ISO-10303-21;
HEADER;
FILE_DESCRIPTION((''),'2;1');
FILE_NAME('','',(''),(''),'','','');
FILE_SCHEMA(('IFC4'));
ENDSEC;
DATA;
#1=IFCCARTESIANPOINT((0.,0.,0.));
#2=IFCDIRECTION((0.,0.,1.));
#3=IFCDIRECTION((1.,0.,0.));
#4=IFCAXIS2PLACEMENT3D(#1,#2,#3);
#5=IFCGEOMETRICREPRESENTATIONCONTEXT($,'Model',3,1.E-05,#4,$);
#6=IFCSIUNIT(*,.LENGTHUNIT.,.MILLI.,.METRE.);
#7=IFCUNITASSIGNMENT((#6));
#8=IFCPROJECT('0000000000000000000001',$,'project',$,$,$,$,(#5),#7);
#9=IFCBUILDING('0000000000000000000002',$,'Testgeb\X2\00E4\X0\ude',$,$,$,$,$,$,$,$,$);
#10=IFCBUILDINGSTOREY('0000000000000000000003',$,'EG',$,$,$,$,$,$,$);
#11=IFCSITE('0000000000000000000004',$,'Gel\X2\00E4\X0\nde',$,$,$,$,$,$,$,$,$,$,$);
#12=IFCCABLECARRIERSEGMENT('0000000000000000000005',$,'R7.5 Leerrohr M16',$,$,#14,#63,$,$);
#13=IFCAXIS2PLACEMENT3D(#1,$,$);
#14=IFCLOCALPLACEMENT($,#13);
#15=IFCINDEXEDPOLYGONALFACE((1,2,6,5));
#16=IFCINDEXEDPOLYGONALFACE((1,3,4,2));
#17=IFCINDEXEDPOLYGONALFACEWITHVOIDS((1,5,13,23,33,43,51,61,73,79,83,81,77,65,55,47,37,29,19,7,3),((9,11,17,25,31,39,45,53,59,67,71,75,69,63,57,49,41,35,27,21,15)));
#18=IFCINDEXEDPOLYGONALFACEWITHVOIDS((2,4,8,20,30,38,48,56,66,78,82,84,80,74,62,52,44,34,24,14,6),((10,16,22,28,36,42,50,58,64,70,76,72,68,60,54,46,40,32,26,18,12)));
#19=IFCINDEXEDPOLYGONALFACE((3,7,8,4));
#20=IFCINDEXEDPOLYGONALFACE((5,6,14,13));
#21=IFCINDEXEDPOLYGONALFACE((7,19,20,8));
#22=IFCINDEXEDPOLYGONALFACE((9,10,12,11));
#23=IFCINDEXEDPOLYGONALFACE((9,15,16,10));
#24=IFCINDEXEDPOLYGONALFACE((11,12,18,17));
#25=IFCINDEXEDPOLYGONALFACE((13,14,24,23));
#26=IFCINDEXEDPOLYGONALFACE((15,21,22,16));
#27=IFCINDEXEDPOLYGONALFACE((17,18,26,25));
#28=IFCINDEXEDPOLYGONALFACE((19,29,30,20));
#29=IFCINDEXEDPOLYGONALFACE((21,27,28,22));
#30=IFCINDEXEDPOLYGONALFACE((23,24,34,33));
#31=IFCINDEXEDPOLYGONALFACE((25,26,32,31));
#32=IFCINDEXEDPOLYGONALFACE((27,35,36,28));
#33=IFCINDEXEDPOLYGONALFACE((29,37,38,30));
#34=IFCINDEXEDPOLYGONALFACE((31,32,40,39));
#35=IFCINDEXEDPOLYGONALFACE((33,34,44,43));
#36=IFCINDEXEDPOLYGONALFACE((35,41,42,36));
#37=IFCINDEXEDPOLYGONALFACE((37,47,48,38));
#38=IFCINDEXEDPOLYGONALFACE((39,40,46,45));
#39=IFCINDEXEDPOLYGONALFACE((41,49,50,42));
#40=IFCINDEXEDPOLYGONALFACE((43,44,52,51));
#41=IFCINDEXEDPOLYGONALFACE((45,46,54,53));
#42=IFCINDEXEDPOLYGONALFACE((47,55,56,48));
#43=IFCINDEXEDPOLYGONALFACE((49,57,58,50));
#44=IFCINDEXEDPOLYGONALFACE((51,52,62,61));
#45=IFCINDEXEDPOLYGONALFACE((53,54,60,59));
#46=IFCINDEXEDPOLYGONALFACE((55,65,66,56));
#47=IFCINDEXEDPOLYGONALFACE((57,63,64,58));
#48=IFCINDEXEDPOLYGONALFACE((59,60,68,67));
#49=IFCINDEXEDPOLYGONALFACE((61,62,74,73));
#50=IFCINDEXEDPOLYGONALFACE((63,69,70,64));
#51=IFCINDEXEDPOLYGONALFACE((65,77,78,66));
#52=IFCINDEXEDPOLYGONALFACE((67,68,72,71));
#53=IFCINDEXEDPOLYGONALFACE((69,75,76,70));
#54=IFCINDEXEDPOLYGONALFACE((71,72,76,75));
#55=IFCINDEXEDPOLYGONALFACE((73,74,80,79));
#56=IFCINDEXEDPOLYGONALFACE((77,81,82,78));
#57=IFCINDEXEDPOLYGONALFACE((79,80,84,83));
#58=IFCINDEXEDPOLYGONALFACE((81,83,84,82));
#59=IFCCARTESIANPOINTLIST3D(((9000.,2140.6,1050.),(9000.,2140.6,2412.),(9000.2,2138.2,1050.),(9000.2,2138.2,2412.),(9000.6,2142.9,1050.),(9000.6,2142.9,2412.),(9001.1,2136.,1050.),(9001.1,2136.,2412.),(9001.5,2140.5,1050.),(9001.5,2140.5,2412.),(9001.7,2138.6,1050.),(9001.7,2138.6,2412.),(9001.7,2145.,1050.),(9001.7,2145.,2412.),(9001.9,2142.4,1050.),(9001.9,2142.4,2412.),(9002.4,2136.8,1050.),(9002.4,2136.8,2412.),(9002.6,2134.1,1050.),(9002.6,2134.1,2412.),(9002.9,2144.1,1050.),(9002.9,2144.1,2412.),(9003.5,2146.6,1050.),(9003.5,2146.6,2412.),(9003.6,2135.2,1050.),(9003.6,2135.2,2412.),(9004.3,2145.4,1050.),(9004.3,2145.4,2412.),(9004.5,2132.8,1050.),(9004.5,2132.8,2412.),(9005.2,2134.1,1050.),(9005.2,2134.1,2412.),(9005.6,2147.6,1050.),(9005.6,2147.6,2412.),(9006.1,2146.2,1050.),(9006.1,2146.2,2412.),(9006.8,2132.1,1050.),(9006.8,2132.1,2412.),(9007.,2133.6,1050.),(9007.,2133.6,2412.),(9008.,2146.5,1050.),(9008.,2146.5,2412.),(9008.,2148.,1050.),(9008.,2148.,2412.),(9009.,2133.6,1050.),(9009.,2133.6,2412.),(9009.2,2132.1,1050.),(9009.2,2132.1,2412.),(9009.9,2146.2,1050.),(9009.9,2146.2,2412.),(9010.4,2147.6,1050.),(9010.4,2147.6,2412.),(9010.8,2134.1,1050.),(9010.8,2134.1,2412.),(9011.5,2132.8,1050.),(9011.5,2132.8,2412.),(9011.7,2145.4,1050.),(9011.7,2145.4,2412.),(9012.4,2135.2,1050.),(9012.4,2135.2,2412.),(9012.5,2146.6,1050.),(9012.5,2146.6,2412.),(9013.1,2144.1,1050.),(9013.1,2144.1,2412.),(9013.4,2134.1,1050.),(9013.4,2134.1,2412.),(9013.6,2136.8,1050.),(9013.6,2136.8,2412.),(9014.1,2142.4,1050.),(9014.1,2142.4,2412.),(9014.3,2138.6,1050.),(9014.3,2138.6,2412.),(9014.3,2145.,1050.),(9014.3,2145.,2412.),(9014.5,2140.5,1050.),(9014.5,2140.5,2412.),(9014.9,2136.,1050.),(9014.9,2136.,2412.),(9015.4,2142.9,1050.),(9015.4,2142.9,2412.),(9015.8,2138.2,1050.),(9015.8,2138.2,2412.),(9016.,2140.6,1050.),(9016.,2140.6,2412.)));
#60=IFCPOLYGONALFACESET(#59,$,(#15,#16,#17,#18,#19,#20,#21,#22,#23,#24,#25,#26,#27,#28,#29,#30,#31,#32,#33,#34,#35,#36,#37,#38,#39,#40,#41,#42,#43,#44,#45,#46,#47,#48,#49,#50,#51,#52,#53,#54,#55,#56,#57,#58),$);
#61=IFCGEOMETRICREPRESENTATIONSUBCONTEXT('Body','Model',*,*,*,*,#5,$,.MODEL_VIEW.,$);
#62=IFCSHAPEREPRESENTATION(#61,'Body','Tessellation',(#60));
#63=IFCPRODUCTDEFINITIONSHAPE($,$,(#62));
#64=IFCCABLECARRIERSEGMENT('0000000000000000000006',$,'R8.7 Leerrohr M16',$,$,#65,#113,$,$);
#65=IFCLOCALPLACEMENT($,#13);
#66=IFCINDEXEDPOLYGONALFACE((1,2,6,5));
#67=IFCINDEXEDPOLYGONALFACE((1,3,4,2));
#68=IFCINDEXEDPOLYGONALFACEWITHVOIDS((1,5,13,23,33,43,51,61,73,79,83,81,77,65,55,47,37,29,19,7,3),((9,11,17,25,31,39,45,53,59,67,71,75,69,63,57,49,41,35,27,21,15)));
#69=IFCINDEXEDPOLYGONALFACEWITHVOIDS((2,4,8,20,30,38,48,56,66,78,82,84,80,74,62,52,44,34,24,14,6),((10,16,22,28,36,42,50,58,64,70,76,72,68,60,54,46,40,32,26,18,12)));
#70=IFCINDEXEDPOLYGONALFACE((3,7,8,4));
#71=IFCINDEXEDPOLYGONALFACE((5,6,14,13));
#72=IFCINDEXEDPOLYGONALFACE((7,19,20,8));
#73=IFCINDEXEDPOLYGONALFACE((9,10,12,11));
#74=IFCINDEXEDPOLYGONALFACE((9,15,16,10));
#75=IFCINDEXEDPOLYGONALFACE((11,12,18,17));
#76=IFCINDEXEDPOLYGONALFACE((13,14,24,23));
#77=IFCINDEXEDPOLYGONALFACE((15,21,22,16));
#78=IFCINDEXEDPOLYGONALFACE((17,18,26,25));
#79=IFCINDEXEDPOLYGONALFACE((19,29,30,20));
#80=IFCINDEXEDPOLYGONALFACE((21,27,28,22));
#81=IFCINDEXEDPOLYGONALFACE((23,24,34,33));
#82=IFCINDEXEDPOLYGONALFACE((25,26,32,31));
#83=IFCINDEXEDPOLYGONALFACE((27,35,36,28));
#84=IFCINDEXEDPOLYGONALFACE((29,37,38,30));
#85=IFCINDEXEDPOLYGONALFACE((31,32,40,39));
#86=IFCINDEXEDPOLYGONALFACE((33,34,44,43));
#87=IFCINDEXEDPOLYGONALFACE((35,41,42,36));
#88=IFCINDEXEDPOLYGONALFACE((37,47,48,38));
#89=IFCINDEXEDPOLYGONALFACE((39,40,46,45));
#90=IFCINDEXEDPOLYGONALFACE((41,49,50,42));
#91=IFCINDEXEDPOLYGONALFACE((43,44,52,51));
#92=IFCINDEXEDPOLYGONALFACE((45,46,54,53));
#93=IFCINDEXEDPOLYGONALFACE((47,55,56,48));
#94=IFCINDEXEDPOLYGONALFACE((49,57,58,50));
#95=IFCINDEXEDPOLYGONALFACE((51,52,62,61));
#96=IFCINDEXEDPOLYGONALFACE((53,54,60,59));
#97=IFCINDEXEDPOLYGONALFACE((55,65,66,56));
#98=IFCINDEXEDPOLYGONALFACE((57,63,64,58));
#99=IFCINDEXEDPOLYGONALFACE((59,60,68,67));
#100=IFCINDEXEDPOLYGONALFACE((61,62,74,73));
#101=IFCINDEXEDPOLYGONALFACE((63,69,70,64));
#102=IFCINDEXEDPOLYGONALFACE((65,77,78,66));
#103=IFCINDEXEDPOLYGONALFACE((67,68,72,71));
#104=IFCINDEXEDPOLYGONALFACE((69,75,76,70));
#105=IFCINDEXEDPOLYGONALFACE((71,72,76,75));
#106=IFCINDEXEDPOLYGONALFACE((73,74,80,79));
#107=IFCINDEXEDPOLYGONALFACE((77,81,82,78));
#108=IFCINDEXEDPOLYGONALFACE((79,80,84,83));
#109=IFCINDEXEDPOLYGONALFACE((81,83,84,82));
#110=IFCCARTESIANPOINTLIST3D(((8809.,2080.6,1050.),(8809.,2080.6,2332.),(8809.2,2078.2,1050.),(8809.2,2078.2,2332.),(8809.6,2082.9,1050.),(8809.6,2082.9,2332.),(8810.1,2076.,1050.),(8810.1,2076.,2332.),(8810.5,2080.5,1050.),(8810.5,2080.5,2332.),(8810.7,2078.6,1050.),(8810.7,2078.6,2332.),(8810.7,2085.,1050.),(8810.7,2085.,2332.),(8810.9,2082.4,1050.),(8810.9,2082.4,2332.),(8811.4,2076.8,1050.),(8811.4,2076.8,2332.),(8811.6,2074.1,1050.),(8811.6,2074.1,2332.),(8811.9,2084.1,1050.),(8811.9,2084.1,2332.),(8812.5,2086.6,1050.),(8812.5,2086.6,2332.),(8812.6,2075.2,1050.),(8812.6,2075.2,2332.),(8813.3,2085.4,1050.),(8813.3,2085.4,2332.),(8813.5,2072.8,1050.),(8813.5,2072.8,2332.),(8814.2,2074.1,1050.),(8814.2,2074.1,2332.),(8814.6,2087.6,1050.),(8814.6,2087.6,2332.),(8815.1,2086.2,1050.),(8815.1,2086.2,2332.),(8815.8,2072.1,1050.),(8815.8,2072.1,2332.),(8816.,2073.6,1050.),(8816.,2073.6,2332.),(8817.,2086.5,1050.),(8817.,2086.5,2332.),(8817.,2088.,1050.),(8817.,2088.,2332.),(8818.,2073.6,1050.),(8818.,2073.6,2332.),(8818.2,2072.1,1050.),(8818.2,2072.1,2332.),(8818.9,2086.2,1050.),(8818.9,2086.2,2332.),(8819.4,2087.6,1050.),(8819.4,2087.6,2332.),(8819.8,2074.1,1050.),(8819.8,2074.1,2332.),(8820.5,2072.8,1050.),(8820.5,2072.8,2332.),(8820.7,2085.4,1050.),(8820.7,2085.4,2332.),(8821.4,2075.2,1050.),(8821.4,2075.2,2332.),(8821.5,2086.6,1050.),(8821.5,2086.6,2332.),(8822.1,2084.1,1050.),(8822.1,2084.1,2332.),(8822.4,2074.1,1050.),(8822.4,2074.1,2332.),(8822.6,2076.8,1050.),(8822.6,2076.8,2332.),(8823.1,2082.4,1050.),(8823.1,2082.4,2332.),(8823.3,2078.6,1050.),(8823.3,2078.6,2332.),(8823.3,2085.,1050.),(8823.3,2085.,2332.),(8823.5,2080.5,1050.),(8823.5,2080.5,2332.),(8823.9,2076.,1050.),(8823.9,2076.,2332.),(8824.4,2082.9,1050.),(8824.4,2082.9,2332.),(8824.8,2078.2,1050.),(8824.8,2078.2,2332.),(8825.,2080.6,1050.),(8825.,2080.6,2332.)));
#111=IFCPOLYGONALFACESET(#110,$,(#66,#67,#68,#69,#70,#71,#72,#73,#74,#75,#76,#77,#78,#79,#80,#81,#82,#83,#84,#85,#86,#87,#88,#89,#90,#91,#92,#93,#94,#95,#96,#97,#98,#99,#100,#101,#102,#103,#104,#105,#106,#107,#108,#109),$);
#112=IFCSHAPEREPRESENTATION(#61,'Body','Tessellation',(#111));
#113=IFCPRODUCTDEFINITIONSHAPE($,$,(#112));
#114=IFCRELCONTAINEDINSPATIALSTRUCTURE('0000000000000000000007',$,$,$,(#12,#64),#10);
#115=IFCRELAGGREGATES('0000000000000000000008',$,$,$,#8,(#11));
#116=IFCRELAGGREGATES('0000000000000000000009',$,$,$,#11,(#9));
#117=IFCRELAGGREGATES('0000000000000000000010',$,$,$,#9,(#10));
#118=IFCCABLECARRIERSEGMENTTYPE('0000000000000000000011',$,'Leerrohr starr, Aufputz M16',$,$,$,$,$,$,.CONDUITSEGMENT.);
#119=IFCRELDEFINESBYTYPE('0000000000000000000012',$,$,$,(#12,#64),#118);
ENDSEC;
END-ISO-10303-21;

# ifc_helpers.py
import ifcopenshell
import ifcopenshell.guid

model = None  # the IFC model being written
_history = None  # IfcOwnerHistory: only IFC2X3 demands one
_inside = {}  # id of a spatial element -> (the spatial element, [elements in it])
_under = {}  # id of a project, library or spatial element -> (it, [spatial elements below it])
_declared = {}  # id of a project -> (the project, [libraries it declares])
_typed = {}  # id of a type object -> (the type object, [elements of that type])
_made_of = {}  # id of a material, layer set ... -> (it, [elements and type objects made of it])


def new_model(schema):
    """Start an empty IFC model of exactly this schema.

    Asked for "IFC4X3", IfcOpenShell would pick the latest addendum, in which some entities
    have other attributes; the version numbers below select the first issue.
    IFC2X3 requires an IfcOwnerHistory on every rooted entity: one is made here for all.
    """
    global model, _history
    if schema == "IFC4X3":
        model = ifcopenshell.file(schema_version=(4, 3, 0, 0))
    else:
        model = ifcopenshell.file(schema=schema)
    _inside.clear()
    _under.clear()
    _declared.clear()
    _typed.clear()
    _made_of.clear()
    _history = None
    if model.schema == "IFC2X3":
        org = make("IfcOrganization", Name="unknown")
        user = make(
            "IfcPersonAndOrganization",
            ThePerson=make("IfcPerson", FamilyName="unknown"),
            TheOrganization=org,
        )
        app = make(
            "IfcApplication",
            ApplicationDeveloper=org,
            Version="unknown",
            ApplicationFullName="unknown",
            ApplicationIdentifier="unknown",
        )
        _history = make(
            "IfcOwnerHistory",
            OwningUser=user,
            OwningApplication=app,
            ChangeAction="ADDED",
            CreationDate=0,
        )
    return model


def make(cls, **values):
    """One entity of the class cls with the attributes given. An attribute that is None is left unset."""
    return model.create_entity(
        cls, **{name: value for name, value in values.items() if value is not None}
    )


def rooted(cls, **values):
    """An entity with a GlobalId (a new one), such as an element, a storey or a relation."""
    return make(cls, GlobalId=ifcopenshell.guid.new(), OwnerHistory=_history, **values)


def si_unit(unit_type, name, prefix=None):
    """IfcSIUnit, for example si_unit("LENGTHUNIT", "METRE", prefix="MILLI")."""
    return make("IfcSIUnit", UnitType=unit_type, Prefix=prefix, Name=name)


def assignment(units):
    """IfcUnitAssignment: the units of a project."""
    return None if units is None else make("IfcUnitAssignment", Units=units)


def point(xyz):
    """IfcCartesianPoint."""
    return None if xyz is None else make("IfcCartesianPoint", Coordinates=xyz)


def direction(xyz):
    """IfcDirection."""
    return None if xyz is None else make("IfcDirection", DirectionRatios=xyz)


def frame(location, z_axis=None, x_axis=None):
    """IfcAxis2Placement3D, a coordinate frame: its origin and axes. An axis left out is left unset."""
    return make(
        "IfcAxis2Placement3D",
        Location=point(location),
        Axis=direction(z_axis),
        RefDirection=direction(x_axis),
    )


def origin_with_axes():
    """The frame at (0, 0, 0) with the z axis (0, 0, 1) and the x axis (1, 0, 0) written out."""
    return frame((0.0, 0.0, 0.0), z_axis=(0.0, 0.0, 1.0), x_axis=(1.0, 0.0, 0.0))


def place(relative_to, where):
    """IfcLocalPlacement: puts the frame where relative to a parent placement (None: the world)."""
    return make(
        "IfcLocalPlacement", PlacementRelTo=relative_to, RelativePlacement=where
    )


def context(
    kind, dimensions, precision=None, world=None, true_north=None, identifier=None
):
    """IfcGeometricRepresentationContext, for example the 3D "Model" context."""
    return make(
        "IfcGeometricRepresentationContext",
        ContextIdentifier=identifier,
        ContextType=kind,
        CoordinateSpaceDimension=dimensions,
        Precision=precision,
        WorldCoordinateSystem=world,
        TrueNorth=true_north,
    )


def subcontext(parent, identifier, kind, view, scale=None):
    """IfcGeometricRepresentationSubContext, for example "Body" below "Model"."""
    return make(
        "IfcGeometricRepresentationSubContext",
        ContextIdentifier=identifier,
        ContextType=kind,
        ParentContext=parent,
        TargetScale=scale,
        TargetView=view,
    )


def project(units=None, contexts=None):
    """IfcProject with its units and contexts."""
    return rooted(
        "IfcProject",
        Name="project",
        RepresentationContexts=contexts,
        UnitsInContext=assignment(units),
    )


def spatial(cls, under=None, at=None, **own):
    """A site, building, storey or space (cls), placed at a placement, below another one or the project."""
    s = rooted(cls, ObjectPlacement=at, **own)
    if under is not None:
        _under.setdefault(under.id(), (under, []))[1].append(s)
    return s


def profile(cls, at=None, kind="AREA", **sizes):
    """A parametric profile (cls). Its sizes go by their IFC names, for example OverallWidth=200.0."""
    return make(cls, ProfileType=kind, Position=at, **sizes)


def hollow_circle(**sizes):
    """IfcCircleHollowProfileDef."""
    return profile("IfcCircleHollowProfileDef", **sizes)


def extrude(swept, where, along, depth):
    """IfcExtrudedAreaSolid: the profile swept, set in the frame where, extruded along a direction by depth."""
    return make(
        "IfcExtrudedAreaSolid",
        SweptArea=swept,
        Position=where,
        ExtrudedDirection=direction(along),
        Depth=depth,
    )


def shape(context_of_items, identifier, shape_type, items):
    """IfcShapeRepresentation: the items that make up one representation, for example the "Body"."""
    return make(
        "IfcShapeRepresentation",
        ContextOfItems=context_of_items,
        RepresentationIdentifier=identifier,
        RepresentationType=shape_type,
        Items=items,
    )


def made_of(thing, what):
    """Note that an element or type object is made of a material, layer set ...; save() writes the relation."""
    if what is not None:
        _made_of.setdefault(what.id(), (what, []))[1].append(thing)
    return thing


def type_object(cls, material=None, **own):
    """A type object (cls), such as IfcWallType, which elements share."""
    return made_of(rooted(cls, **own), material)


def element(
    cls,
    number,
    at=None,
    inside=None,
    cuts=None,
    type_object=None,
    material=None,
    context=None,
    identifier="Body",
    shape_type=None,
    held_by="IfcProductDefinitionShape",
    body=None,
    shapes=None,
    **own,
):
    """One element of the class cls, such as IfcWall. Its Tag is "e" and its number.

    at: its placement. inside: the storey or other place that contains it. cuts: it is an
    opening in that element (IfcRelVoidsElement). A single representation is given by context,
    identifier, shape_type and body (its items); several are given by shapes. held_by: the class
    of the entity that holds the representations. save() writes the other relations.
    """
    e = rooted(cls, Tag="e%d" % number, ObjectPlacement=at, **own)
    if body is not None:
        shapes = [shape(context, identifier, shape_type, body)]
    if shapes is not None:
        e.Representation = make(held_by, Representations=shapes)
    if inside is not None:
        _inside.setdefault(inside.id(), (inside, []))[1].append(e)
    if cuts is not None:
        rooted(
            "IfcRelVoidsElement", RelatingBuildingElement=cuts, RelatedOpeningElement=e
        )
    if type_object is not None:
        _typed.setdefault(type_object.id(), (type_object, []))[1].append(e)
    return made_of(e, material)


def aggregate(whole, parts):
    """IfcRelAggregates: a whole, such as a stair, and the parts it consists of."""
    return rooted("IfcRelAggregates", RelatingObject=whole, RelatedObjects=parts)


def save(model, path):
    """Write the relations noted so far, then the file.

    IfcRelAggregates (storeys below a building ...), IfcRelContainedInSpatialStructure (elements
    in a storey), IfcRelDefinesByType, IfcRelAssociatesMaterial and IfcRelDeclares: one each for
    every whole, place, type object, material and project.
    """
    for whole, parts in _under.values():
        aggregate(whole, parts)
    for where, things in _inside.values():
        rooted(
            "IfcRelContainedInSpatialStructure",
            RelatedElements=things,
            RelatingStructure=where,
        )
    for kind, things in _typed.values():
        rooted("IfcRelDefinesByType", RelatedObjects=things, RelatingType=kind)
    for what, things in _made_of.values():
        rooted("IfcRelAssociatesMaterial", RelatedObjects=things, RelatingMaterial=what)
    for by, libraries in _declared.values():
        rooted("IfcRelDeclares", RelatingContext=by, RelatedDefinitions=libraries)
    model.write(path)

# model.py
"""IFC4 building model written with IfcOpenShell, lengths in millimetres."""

from ifc_helpers import new_model, si_unit, frame, origin_with_axes, place, context, subcontext, project, spatial, hollow_circle, extrude, type_object, element, save


model = new_model("IFC4")

# Units and contexts
model_context = context("Model", 3, precision=1e-05, world=origin_with_axes())
body_context = subcontext(model_context, "Body", "Model", "MODEL_VIEW")
ifc_project = project(units=[si_unit("LENGTHUNIT", "METRE", prefix="MILLI")], contexts=[model_context])

# Site, building, storey
site = spatial("IfcSite", under=ifc_project, Name="Gelände")
building = spatial("IfcBuilding", under=site, Name="Testgebäude")
storey = spatial("IfcBuildingStorey", under=building, Name="EG")

# Cable carrier segments
cable_carrier_segment_type_1 = type_object("IfcCableCarrierSegmentType", Name="Leerrohr starr, Aufputz M16", PredefinedType="CONDUITSEGMENT")
cable_carrier_segment_1_placement = place(None, frame((9008.0, 2140.0, 2412.0), z_axis=(0.0, 0.0, -1.0), x_axis=(0.0, 1.0, 0.0)))
element("IfcCableCarrierSegment", 1, at=cable_carrier_segment_1_placement, inside=storey, type_object=cable_carrier_segment_type_1, Name="R7.5 Leerrohr M16", context=body_context, shape_type="SweptSolid", body=[
    extrude(hollow_circle(Radius=8.0, WallThickness=1.5), None, (0.0, 0.0, 1.0), 1362.0),
])
cable_carrier_segment_2_placement = place(None, frame((8817.0, 2080.0, 2332.0), z_axis=(0.0, 0.0, -1.0), x_axis=(0.0, 1.0, 0.0)))
element("IfcCableCarrierSegment", 2, at=cable_carrier_segment_2_placement, inside=storey, type_object=cable_carrier_segment_type_1, Name="R8.7 Leerrohr M16", context=body_context, shape_type="SweptSolid", body=[
    extrude(hollow_circle(Radius=8.0, WallThickness=1.5), None, (0.0, 0.0, 1.0), 1282.0),
])

save(model, "model.ifc")
